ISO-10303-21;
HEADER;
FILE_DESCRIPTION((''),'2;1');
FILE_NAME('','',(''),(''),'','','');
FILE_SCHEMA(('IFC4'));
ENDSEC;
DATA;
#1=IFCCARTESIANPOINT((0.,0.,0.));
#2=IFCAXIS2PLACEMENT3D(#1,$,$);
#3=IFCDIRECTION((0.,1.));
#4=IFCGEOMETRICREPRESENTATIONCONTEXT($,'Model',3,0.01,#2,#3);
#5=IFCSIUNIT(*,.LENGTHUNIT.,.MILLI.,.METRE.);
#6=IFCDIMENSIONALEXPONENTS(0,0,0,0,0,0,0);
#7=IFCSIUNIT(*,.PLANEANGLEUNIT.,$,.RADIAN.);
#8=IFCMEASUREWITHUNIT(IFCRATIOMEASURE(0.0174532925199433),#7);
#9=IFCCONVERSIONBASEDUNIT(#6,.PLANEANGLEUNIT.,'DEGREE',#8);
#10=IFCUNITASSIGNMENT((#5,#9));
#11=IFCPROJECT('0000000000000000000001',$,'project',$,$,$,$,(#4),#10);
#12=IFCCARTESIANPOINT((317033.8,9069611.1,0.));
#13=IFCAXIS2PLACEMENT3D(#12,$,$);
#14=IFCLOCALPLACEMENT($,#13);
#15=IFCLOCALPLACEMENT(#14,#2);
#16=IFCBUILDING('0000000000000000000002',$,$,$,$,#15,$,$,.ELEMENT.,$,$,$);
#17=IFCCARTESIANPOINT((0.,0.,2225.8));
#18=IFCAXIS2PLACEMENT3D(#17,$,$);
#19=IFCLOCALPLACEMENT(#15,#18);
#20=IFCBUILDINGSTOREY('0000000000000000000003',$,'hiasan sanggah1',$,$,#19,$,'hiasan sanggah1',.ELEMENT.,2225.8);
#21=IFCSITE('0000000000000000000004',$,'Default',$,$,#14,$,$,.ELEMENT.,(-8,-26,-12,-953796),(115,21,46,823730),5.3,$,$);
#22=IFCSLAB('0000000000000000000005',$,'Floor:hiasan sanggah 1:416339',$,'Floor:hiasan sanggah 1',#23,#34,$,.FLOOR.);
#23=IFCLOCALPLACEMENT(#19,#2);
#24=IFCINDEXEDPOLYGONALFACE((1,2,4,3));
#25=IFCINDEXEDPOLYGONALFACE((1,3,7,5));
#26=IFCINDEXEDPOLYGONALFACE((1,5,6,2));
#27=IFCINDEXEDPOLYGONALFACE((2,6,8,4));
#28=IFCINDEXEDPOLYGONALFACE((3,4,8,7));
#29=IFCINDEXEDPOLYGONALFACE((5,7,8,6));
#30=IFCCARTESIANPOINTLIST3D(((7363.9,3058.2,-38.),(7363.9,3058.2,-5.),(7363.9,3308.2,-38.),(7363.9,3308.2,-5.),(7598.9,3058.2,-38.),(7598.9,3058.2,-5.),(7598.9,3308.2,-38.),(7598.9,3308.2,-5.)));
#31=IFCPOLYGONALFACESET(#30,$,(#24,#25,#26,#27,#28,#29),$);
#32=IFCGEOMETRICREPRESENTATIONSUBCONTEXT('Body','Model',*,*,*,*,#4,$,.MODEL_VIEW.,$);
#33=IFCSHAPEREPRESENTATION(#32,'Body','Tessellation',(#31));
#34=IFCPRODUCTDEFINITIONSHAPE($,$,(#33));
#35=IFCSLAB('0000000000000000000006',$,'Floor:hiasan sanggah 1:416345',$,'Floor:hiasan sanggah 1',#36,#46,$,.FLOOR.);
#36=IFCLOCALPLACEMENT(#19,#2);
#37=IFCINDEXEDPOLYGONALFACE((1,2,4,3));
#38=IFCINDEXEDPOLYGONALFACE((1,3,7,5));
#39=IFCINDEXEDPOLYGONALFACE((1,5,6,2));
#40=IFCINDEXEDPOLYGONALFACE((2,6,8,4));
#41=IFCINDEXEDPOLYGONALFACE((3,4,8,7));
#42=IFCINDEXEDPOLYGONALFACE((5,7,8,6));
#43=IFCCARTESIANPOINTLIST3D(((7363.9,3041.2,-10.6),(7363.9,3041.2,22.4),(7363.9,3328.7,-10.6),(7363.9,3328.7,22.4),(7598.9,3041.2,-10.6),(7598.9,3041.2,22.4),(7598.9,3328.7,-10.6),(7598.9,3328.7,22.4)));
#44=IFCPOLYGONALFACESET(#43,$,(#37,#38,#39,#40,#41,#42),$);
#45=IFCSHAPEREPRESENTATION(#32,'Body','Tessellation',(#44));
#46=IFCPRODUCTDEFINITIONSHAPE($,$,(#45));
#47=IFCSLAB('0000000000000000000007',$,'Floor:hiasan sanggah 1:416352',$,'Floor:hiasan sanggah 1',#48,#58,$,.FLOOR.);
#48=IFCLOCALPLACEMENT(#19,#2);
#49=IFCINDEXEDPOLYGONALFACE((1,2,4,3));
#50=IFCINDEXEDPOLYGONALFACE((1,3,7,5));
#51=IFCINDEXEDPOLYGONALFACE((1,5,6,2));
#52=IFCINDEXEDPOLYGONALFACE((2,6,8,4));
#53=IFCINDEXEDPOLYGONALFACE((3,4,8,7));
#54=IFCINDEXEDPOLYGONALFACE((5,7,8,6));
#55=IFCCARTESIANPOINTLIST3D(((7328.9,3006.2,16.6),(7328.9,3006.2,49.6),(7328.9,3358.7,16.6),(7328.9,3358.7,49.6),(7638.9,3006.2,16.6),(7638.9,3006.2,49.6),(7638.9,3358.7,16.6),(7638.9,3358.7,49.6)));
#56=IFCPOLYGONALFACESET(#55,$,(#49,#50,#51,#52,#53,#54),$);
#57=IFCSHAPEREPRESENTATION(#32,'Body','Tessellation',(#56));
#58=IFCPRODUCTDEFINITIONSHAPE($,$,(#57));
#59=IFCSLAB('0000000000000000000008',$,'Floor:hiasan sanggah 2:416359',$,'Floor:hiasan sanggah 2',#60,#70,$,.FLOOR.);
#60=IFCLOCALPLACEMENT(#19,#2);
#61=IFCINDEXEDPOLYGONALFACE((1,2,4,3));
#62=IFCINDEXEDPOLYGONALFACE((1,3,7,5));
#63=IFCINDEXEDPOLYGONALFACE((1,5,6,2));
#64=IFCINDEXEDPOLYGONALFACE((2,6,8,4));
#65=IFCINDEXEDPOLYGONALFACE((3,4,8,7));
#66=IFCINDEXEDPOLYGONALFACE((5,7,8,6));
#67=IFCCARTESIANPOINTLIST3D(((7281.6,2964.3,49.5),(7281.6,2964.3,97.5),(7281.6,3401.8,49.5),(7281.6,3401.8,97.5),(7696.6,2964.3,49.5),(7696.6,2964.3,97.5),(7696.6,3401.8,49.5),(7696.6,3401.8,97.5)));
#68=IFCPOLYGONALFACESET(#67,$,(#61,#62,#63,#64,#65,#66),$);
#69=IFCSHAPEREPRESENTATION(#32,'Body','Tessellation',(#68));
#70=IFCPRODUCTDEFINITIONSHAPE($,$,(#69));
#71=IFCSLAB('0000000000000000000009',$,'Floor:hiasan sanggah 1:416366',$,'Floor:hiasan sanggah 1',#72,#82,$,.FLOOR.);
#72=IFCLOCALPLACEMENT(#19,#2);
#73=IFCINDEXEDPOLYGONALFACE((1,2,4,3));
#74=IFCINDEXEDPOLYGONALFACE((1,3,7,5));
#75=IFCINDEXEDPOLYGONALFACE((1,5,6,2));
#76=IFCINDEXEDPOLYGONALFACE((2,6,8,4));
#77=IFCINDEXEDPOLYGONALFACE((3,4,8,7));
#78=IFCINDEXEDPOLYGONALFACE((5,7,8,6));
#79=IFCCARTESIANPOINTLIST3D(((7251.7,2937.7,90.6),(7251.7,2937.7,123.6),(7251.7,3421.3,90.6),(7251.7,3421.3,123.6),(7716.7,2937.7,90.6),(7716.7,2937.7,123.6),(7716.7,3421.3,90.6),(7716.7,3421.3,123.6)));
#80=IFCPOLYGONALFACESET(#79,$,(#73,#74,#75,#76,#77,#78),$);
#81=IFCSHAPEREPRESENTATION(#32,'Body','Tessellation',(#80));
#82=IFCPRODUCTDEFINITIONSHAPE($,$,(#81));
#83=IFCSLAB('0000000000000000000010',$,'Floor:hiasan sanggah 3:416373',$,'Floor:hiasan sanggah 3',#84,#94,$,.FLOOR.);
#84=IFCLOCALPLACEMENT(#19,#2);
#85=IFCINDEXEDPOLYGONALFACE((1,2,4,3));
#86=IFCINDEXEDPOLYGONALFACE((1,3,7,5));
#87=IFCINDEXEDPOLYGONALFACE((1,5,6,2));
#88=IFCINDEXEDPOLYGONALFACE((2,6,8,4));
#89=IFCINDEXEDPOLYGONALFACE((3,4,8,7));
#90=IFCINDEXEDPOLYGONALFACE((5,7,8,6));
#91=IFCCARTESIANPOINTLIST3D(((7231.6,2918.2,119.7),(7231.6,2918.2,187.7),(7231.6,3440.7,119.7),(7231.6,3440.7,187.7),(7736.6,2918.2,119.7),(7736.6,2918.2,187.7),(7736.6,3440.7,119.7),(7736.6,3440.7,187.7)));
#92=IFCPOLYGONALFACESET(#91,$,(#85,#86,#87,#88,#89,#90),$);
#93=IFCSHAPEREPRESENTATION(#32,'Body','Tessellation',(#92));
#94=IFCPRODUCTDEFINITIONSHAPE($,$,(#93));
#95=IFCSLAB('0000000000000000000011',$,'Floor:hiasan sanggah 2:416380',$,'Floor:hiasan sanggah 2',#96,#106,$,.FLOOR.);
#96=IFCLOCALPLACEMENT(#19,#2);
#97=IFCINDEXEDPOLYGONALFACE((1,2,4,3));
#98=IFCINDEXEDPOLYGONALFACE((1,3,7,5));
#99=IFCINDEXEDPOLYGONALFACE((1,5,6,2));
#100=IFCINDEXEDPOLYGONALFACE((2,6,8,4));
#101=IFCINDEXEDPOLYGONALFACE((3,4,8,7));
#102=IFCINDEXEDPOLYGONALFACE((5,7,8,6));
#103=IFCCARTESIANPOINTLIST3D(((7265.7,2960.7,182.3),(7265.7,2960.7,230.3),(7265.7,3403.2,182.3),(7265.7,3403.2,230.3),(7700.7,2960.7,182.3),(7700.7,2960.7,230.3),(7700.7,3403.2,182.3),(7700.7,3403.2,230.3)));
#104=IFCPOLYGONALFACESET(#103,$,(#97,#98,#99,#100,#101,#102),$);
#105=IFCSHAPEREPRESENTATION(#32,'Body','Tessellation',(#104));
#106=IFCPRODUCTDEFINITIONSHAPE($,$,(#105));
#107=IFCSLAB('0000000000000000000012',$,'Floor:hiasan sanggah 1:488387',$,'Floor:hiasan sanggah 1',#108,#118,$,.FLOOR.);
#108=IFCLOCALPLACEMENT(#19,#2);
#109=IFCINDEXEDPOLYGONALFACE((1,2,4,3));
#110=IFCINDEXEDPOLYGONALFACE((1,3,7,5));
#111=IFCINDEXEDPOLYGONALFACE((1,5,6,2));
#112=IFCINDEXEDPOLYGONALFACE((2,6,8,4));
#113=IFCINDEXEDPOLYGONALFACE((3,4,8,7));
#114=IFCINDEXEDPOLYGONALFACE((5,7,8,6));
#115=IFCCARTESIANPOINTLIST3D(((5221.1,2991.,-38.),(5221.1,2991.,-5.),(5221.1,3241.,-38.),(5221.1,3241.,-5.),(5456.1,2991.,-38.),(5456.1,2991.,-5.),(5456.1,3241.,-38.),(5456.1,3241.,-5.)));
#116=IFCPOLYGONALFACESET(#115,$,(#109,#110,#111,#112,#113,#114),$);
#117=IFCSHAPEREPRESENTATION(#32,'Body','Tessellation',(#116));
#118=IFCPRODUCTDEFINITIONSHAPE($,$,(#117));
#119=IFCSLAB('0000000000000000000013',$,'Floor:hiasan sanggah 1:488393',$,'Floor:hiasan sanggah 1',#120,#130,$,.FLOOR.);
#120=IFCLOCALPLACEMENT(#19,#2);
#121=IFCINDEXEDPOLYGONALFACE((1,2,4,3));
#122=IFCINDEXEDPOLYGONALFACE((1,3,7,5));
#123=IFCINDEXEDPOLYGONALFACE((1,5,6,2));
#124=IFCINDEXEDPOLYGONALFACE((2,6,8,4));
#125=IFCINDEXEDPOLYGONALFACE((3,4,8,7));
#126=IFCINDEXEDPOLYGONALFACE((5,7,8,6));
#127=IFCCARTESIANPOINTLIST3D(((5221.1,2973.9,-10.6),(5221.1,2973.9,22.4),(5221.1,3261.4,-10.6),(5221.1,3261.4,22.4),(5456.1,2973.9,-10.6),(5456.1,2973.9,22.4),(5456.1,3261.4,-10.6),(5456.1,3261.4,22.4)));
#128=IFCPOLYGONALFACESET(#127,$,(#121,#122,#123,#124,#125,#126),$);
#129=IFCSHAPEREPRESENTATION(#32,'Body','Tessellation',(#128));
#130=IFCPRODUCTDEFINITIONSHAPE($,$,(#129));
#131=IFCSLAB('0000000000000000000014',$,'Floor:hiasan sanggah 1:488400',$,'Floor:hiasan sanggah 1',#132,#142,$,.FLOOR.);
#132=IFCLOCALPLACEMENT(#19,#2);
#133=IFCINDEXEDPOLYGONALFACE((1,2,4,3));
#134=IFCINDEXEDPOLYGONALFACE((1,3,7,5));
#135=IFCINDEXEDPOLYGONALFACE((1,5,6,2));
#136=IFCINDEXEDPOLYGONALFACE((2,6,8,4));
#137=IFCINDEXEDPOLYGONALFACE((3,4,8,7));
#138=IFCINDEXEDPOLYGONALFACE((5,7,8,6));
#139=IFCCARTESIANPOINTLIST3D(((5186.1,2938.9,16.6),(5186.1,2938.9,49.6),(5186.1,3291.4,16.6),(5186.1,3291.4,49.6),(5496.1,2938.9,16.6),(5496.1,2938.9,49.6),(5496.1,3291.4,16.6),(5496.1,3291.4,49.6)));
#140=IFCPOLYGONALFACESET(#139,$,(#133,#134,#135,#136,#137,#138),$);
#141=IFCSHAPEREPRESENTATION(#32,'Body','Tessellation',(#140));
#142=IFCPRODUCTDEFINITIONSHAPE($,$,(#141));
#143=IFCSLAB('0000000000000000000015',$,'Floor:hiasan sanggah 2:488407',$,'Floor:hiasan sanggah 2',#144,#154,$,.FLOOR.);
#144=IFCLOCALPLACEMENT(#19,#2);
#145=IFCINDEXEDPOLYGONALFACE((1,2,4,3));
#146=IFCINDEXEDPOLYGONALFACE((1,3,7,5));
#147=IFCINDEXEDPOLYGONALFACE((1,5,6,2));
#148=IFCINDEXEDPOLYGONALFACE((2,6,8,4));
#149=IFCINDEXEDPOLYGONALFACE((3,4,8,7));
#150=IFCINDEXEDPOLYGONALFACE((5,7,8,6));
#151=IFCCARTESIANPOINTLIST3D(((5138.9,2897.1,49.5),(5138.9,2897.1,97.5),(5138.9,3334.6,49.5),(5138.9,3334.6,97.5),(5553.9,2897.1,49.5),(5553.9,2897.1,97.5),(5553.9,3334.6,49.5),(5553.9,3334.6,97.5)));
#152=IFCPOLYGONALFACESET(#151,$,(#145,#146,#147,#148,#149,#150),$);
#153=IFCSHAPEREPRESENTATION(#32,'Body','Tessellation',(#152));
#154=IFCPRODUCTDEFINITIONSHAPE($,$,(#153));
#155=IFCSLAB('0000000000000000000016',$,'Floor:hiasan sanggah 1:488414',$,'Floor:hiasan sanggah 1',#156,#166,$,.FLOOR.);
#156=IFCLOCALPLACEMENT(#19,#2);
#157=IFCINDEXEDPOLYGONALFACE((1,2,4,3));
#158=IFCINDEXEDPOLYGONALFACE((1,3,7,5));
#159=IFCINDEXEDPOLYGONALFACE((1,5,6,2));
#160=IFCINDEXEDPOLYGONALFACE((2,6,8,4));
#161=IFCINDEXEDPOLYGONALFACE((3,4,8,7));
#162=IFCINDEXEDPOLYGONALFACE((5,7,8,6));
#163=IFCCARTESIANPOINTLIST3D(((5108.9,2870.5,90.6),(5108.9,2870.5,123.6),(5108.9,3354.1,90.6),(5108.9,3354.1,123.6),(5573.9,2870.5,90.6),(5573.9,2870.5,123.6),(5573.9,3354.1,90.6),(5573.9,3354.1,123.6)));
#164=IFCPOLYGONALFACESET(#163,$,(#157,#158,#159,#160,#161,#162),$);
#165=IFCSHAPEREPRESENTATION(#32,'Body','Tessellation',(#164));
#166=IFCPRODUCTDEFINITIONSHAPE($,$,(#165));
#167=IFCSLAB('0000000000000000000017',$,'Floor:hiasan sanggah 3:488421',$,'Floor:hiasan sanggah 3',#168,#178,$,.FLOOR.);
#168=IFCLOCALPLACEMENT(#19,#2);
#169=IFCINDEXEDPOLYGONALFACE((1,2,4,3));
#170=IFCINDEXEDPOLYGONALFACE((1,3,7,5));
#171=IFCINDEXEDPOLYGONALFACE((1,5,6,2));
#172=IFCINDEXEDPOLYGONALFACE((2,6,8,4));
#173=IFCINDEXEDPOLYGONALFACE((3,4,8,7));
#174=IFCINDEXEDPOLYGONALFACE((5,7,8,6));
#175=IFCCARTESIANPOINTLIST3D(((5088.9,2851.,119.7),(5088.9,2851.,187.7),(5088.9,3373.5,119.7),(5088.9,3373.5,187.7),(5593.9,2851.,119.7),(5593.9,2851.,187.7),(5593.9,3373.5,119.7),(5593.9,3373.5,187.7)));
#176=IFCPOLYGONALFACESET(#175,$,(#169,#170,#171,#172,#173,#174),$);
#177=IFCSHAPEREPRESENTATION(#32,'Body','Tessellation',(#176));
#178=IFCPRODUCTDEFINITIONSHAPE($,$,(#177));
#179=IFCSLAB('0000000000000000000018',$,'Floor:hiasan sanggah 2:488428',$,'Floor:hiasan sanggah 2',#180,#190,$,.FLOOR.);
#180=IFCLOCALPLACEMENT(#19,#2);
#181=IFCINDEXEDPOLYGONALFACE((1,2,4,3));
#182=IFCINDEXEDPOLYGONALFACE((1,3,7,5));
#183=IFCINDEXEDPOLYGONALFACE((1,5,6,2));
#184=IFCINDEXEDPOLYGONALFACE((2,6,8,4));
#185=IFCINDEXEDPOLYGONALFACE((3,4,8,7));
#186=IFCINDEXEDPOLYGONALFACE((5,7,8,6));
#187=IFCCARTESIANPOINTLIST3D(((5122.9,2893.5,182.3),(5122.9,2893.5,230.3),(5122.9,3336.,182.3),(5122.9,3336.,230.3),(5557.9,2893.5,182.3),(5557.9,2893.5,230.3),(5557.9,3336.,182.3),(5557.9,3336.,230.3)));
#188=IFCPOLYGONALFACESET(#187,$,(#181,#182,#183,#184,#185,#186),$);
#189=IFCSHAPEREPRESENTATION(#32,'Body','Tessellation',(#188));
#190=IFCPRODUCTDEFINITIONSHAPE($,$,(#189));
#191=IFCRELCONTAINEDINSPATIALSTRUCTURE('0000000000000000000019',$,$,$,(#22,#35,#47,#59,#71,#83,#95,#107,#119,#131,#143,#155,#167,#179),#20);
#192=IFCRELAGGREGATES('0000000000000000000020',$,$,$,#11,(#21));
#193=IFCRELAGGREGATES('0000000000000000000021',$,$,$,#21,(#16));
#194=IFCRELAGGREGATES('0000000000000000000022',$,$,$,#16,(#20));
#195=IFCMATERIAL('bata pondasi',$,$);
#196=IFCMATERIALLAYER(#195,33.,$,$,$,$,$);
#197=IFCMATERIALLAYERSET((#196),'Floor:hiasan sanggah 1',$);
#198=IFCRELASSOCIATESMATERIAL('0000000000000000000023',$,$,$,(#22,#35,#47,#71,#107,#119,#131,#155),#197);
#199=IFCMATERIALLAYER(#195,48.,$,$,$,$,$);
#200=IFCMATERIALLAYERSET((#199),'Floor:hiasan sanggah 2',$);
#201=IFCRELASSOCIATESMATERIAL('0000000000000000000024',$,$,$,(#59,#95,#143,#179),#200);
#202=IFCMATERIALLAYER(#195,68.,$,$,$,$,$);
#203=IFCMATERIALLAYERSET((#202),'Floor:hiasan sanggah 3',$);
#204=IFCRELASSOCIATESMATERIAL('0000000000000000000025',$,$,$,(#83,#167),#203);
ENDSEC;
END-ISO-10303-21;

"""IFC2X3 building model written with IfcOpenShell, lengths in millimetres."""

from ifc_helpers import new_model, entity, si_unit, converted_unit, direction, frame, frame_2d, origin, origin_2d_with_axis, place, context, subcontext, project, spatial, rectangle, extrude, material, layer, layer_set, layer_usage, element, save


model = new_model("IFC2X3")

# Units and contexts
model_context = context("Model", 3, precision=0.01, world=origin(), true_north=direction((0.0, 1.0)))
body_context = subcontext(model_context, "Body", "Model", "MODEL_VIEW")
ifc_project = project(units=[si_unit("LENGTHUNIT", "METRE", prefix="MILLI"), converted_unit("PLANEANGLEUNIT", "DEGREE", entity("IfcRatioMeasure", 0.0174532925199433), si_unit("PLANEANGLEUNIT", "RADIAN"), dimensions=[0, 0, 0, 0, 0, 0, 0])], contexts=[model_context])

# Site, building, storey
site_placement = place(None, frame((317033.8, 9069611.1, 0.0)))
site = spatial("IfcSite", under=ifc_project, at=site_placement, Name="Default", CompositionType="ELEMENT", RefLatitude=(-8, -26, -12, -953796), RefLongitude=(115, 21, 46, 823730), RefElevation=5.3)
building_placement = place(site_placement, origin())
building = spatial("IfcBuilding", under=site, at=building_placement, CompositionType="ELEMENT")
storey_placement = place(building_placement, frame((0.0, 0.0, 2225.8)))
storey = spatial("IfcBuildingStorey", under=building, at=storey_placement, Name="hiasan sanggah1", LongName="hiasan sanggah1", CompositionType="ELEMENT", Elevation=2225.8)

# Slabs
ifc_material = material(Name="bata pondasi")
ifc_layer_1 = layer(ifc_material, 33.0)
ifc_layer_set_1 = layer_set([ifc_layer_1], Name="Floor:hiasan sanggah 1")
ifc_layer_2 = layer(ifc_material, 48.0)
ifc_layer_set_2 = layer_set([ifc_layer_2], Name="Floor:hiasan sanggah 2")
ifc_layer_3 = layer(ifc_material, 68.0)
ifc_layer_set_3 = layer_set([ifc_layer_3], Name="Floor:hiasan sanggah 3")
ifc_layer_usage_1 = layer_usage(ifc_layer_set_1, "AXIS3", "POSITIVE", 0.0)
slab_1_placement = place(storey_placement, origin())
element("IfcSlab", 1, at=slab_1_placement, inside=storey, material=ifc_layer_usage_1, Name="Floor:hiasan sanggah 1:416339", ObjectType="Floor:hiasan sanggah 1", PredefinedType="FLOOR", context=body_context, shape_type="SweptSolid", body=[
    extrude(rectangle(XDim=250.0, YDim=235.0, at=frame_2d((0.0, 0.0), x_axis=(1.0, 0.0))), frame((7481.4, 3183.2, -5.0), z_axis=(0.0, 0.0, -1.0), x_axis=(0.0, 1.0, 0.0)), (0.0, 0.0, 1.0), 33.0),
])
ifc_layer_usage_2 = layer_usage(ifc_layer_set_1, "AXIS3", "POSITIVE", 0.0)
slab_2_placement = place(storey_placement, origin())
element("IfcSlab", 2, at=slab_2_placement, inside=storey, material=ifc_layer_usage_2, Name="Floor:hiasan sanggah 1:416345", ObjectType="Floor:hiasan sanggah 1", PredefinedType="FLOOR", context=body_context, shape_type="SweptSolid", body=[
    extrude(rectangle(XDim=287.5, YDim=235.0, at=frame_2d((0.0, 0.0), x_axis=(1.0, 0.0))), frame((7481.4, 3184.9, 22.4), z_axis=(0.0, 0.0, -1.0), x_axis=(0.0, 1.0, 0.0)), (0.0, 0.0, 1.0), 33.0),
])
ifc_layer_usage_3 = layer_usage(ifc_layer_set_1, "AXIS3", "POSITIVE", 0.0)
slab_3_placement = place(storey_placement, origin())
element("IfcSlab", 3, at=slab_3_placement, inside=storey, material=ifc_layer_usage_3, Name="Floor:hiasan sanggah 1:416352", ObjectType="Floor:hiasan sanggah 1", PredefinedType="FLOOR", context=body_context, shape_type="SweptSolid", body=[
    extrude(rectangle(XDim=352.5, YDim=310.0, at=origin_2d_with_axis()), frame((7483.9, 3182.4, 49.6), z_axis=(0.0, 0.0, -1.0), x_axis=(0.0, 1.0, 0.0)), (0.0, 0.0, 1.0), 33.0),
])
ifc_layer_usage_4 = layer_usage(ifc_layer_set_2, "AXIS3", "POSITIVE", 0.0)
slab_4_placement = place(storey_placement, origin())
element("IfcSlab", 4, at=slab_4_placement, inside=storey, material=ifc_layer_usage_4, Name="Floor:hiasan sanggah 2:416359", ObjectType="Floor:hiasan sanggah 2", PredefinedType="FLOOR", context=body_context, shape_type="SweptSolid", body=[
    extrude(rectangle(XDim=437.5, YDim=415.0, at=frame_2d((0.0, 0.0), x_axis=(1.0, 0.0))), frame((7489.1, 3183.0, 97.5), z_axis=(0.0, 0.0, -1.0), x_axis=(0.0, 1.0, 0.0)), (0.0, 0.0, 1.0), 48.0),
])
ifc_layer_usage_5 = layer_usage(ifc_layer_set_1, "AXIS3", "POSITIVE", 0.0)
slab_5_placement = place(storey_placement, origin())
element("IfcSlab", 5, at=slab_5_placement, inside=storey, material=ifc_layer_usage_5, Name="Floor:hiasan sanggah 1:416366", ObjectType="Floor:hiasan sanggah 1", PredefinedType="FLOOR", context=body_context, shape_type="SweptSolid", body=[
    extrude(rectangle(XDim=483.7, YDim=465.0, at=frame_2d((0.0, 0.0), x_axis=(1.0, 0.0))), frame((7484.2, 3179.5, 123.6), z_axis=(0.0, 0.0, -1.0), x_axis=(0.0, 1.0, 0.0)), (0.0, 0.0, 1.0), 33.0),
])
ifc_layer_usage_6 = layer_usage(ifc_layer_set_3, "AXIS3", "POSITIVE", 0.0)
slab_6_placement = place(storey_placement, origin())
element("IfcSlab", 6, at=slab_6_placement, inside=storey, material=ifc_layer_usage_6, Name="Floor:hiasan sanggah 3:416373", ObjectType="Floor:hiasan sanggah 3", PredefinedType="FLOOR", context=body_context, shape_type="SweptSolid", body=[
    extrude(rectangle(XDim=522.5, YDim=505.0, at=frame_2d((0.0, 0.0), x_axis=(1.0, 0.0))), frame((7484.1, 3179.5, 187.7), z_axis=(0.0, 0.0, -1.0), x_axis=(0.0, 1.0, 0.0)), (0.0, 0.0, 1.0), 68.0),
])
ifc_layer_usage_7 = layer_usage(ifc_layer_set_2, "AXIS3", "POSITIVE", 0.0)
slab_7_placement = place(storey_placement, origin())
element("IfcSlab", 7, at=slab_7_placement, inside=storey, material=ifc_layer_usage_7, Name="Floor:hiasan sanggah 2:416380", ObjectType="Floor:hiasan sanggah 2", PredefinedType="FLOOR", context=body_context, shape_type="SweptSolid", body=[
    extrude(rectangle(XDim=442.5, YDim=435.0, at=frame_2d((0.0, 0.0), x_axis=(1.0, 0.0))), frame((7483.2, 3182.0, 230.3), z_axis=(0.0, 0.0, -1.0), x_axis=(0.0, 1.0, 0.0)), (0.0, 0.0, 1.0), 48.0),
])
ifc_layer_usage_8 = layer_usage(ifc_layer_set_1, "AXIS3", "POSITIVE", 0.0)
slab_8_placement = place(storey_placement, origin())
element("IfcSlab", 8, at=slab_8_placement, inside=storey, material=ifc_layer_usage_8, Name="Floor:hiasan sanggah 1:488387", ObjectType="Floor:hiasan sanggah 1", PredefinedType="FLOOR", context=body_context, shape_type="SweptSolid", body=[
    extrude(rectangle(XDim=250.0, YDim=235.0, at=frame_2d((0.0, 0.0), x_axis=(1.0, 0.0))), frame((5338.6, 3116.0, -5.0), z_axis=(0.0, 0.0, -1.0), x_axis=(0.0, 1.0, 0.0)), (0.0, 0.0, 1.0), 33.0),
])
ifc_layer_usage_9 = layer_usage(ifc_layer_set_1, "AXIS3", "POSITIVE", 0.0)
slab_9_placement = place(storey_placement, origin())
element("IfcSlab", 9, at=slab_9_placement, inside=storey, material=ifc_layer_usage_9, Name="Floor:hiasan sanggah 1:488393", ObjectType="Floor:hiasan sanggah 1", PredefinedType="FLOOR", context=body_context, shape_type="SweptSolid", body=[
    extrude(rectangle(XDim=287.5, YDim=235.0, at=frame_2d((0.0, 0.0), x_axis=(1.0, 0.0))), frame((5338.6, 3117.7, 22.4), z_axis=(0.0, 0.0, -1.0), x_axis=(0.0, 1.0, 0.0)), (0.0, 0.0, 1.0), 33.0),
])
ifc_layer_usage_10 = layer_usage(ifc_layer_set_1, "AXIS3", "POSITIVE", 0.0)
slab_10_placement = place(storey_placement, origin())
element("IfcSlab", 10, at=slab_10_placement, inside=storey, material=ifc_layer_usage_10, Name="Floor:hiasan sanggah 1:488400", ObjectType="Floor:hiasan sanggah 1", PredefinedType="FLOOR", context=body_context, shape_type="SweptSolid", body=[
    extrude(rectangle(XDim=352.5, YDim=310.0, at=origin_2d_with_axis()), frame((5341.1, 3115.2, 49.6), z_axis=(0.0, 0.0, -1.0), x_axis=(0.0, 1.0, 0.0)), (0.0, 0.0, 1.0), 33.0),
])
ifc_layer_usage_11 = layer_usage(ifc_layer_set_2, "AXIS3", "POSITIVE", 0.0)
slab_11_placement = place(storey_placement, origin())
element("IfcSlab", 11, at=slab_11_placement, inside=storey, material=ifc_layer_usage_11, Name="Floor:hiasan sanggah 2:488407", ObjectType="Floor:hiasan sanggah 2", PredefinedType="FLOOR", context=body_context, shape_type="SweptSolid", body=[
    extrude(rectangle(XDim=437.5, YDim=415.0, at=frame_2d((0.0, 0.0), x_axis=(1.0, 0.0))), frame((5346.4, 3115.8, 97.5), z_axis=(0.0, 0.0, -1.0), x_axis=(0.0, 1.0, 0.0)), (0.0, 0.0, 1.0), 48.0),
])
ifc_layer_usage_12 = layer_usage(ifc_layer_set_1, "AXIS3", "POSITIVE", 0.0)
slab_12_placement = place(storey_placement, origin())
element("IfcSlab", 12, at=slab_12_placement, inside=storey, material=ifc_layer_usage_12, Name="Floor:hiasan sanggah 1:488414", ObjectType="Floor:hiasan sanggah 1", PredefinedType="FLOOR", context=body_context, shape_type="SweptSolid", body=[
    extrude(rectangle(XDim=483.7, YDim=465.0, at=frame_2d((0.0, 0.0), x_axis=(1.0, 0.0))), frame((5341.4, 3112.3, 123.6), z_axis=(0.0, 0.0, -1.0), x_axis=(0.0, 1.0, 0.0)), (0.0, 0.0, 1.0), 33.0),
])
ifc_layer_usage_13 = layer_usage(ifc_layer_set_3, "AXIS3", "POSITIVE", 0.0)
slab_13_placement = place(storey_placement, origin())
element("IfcSlab", 13, at=slab_13_placement, inside=storey, material=ifc_layer_usage_13, Name="Floor:hiasan sanggah 3:488421", ObjectType="Floor:hiasan sanggah 3", PredefinedType="FLOOR", context=body_context, shape_type="SweptSolid", body=[
    extrude(rectangle(XDim=522.5, YDim=505.0, at=frame_2d((0.0, 0.0), x_axis=(1.0, 0.0))), frame((5341.4, 3112.3, 187.7), z_axis=(0.0, 0.0, -1.0), x_axis=(0.0, 1.0, 0.0)), (0.0, 0.0, 1.0), 68.0),
])
ifc_layer_usage_14 = layer_usage(ifc_layer_set_2, "AXIS3", "POSITIVE", 0.0)
slab_14_placement = place(storey_placement, origin())
element("IfcSlab", 14, at=slab_14_placement, inside=storey, material=ifc_layer_usage_14, Name="Floor:hiasan sanggah 2:488428", ObjectType="Floor:hiasan sanggah 2", PredefinedType="FLOOR", context=body_context, shape_type="SweptSolid", body=[
    extrude(rectangle(XDim=442.5, YDim=435.0, at=frame_2d((0.0, 0.0), x_axis=(1.0, 0.0))), frame((5340.4, 3114.8, 230.3), z_axis=(0.0, 0.0, -1.0), x_axis=(0.0, 1.0, 0.0)), (0.0, 0.0, 1.0), 48.0),
])

save(model, "model.ifc")
